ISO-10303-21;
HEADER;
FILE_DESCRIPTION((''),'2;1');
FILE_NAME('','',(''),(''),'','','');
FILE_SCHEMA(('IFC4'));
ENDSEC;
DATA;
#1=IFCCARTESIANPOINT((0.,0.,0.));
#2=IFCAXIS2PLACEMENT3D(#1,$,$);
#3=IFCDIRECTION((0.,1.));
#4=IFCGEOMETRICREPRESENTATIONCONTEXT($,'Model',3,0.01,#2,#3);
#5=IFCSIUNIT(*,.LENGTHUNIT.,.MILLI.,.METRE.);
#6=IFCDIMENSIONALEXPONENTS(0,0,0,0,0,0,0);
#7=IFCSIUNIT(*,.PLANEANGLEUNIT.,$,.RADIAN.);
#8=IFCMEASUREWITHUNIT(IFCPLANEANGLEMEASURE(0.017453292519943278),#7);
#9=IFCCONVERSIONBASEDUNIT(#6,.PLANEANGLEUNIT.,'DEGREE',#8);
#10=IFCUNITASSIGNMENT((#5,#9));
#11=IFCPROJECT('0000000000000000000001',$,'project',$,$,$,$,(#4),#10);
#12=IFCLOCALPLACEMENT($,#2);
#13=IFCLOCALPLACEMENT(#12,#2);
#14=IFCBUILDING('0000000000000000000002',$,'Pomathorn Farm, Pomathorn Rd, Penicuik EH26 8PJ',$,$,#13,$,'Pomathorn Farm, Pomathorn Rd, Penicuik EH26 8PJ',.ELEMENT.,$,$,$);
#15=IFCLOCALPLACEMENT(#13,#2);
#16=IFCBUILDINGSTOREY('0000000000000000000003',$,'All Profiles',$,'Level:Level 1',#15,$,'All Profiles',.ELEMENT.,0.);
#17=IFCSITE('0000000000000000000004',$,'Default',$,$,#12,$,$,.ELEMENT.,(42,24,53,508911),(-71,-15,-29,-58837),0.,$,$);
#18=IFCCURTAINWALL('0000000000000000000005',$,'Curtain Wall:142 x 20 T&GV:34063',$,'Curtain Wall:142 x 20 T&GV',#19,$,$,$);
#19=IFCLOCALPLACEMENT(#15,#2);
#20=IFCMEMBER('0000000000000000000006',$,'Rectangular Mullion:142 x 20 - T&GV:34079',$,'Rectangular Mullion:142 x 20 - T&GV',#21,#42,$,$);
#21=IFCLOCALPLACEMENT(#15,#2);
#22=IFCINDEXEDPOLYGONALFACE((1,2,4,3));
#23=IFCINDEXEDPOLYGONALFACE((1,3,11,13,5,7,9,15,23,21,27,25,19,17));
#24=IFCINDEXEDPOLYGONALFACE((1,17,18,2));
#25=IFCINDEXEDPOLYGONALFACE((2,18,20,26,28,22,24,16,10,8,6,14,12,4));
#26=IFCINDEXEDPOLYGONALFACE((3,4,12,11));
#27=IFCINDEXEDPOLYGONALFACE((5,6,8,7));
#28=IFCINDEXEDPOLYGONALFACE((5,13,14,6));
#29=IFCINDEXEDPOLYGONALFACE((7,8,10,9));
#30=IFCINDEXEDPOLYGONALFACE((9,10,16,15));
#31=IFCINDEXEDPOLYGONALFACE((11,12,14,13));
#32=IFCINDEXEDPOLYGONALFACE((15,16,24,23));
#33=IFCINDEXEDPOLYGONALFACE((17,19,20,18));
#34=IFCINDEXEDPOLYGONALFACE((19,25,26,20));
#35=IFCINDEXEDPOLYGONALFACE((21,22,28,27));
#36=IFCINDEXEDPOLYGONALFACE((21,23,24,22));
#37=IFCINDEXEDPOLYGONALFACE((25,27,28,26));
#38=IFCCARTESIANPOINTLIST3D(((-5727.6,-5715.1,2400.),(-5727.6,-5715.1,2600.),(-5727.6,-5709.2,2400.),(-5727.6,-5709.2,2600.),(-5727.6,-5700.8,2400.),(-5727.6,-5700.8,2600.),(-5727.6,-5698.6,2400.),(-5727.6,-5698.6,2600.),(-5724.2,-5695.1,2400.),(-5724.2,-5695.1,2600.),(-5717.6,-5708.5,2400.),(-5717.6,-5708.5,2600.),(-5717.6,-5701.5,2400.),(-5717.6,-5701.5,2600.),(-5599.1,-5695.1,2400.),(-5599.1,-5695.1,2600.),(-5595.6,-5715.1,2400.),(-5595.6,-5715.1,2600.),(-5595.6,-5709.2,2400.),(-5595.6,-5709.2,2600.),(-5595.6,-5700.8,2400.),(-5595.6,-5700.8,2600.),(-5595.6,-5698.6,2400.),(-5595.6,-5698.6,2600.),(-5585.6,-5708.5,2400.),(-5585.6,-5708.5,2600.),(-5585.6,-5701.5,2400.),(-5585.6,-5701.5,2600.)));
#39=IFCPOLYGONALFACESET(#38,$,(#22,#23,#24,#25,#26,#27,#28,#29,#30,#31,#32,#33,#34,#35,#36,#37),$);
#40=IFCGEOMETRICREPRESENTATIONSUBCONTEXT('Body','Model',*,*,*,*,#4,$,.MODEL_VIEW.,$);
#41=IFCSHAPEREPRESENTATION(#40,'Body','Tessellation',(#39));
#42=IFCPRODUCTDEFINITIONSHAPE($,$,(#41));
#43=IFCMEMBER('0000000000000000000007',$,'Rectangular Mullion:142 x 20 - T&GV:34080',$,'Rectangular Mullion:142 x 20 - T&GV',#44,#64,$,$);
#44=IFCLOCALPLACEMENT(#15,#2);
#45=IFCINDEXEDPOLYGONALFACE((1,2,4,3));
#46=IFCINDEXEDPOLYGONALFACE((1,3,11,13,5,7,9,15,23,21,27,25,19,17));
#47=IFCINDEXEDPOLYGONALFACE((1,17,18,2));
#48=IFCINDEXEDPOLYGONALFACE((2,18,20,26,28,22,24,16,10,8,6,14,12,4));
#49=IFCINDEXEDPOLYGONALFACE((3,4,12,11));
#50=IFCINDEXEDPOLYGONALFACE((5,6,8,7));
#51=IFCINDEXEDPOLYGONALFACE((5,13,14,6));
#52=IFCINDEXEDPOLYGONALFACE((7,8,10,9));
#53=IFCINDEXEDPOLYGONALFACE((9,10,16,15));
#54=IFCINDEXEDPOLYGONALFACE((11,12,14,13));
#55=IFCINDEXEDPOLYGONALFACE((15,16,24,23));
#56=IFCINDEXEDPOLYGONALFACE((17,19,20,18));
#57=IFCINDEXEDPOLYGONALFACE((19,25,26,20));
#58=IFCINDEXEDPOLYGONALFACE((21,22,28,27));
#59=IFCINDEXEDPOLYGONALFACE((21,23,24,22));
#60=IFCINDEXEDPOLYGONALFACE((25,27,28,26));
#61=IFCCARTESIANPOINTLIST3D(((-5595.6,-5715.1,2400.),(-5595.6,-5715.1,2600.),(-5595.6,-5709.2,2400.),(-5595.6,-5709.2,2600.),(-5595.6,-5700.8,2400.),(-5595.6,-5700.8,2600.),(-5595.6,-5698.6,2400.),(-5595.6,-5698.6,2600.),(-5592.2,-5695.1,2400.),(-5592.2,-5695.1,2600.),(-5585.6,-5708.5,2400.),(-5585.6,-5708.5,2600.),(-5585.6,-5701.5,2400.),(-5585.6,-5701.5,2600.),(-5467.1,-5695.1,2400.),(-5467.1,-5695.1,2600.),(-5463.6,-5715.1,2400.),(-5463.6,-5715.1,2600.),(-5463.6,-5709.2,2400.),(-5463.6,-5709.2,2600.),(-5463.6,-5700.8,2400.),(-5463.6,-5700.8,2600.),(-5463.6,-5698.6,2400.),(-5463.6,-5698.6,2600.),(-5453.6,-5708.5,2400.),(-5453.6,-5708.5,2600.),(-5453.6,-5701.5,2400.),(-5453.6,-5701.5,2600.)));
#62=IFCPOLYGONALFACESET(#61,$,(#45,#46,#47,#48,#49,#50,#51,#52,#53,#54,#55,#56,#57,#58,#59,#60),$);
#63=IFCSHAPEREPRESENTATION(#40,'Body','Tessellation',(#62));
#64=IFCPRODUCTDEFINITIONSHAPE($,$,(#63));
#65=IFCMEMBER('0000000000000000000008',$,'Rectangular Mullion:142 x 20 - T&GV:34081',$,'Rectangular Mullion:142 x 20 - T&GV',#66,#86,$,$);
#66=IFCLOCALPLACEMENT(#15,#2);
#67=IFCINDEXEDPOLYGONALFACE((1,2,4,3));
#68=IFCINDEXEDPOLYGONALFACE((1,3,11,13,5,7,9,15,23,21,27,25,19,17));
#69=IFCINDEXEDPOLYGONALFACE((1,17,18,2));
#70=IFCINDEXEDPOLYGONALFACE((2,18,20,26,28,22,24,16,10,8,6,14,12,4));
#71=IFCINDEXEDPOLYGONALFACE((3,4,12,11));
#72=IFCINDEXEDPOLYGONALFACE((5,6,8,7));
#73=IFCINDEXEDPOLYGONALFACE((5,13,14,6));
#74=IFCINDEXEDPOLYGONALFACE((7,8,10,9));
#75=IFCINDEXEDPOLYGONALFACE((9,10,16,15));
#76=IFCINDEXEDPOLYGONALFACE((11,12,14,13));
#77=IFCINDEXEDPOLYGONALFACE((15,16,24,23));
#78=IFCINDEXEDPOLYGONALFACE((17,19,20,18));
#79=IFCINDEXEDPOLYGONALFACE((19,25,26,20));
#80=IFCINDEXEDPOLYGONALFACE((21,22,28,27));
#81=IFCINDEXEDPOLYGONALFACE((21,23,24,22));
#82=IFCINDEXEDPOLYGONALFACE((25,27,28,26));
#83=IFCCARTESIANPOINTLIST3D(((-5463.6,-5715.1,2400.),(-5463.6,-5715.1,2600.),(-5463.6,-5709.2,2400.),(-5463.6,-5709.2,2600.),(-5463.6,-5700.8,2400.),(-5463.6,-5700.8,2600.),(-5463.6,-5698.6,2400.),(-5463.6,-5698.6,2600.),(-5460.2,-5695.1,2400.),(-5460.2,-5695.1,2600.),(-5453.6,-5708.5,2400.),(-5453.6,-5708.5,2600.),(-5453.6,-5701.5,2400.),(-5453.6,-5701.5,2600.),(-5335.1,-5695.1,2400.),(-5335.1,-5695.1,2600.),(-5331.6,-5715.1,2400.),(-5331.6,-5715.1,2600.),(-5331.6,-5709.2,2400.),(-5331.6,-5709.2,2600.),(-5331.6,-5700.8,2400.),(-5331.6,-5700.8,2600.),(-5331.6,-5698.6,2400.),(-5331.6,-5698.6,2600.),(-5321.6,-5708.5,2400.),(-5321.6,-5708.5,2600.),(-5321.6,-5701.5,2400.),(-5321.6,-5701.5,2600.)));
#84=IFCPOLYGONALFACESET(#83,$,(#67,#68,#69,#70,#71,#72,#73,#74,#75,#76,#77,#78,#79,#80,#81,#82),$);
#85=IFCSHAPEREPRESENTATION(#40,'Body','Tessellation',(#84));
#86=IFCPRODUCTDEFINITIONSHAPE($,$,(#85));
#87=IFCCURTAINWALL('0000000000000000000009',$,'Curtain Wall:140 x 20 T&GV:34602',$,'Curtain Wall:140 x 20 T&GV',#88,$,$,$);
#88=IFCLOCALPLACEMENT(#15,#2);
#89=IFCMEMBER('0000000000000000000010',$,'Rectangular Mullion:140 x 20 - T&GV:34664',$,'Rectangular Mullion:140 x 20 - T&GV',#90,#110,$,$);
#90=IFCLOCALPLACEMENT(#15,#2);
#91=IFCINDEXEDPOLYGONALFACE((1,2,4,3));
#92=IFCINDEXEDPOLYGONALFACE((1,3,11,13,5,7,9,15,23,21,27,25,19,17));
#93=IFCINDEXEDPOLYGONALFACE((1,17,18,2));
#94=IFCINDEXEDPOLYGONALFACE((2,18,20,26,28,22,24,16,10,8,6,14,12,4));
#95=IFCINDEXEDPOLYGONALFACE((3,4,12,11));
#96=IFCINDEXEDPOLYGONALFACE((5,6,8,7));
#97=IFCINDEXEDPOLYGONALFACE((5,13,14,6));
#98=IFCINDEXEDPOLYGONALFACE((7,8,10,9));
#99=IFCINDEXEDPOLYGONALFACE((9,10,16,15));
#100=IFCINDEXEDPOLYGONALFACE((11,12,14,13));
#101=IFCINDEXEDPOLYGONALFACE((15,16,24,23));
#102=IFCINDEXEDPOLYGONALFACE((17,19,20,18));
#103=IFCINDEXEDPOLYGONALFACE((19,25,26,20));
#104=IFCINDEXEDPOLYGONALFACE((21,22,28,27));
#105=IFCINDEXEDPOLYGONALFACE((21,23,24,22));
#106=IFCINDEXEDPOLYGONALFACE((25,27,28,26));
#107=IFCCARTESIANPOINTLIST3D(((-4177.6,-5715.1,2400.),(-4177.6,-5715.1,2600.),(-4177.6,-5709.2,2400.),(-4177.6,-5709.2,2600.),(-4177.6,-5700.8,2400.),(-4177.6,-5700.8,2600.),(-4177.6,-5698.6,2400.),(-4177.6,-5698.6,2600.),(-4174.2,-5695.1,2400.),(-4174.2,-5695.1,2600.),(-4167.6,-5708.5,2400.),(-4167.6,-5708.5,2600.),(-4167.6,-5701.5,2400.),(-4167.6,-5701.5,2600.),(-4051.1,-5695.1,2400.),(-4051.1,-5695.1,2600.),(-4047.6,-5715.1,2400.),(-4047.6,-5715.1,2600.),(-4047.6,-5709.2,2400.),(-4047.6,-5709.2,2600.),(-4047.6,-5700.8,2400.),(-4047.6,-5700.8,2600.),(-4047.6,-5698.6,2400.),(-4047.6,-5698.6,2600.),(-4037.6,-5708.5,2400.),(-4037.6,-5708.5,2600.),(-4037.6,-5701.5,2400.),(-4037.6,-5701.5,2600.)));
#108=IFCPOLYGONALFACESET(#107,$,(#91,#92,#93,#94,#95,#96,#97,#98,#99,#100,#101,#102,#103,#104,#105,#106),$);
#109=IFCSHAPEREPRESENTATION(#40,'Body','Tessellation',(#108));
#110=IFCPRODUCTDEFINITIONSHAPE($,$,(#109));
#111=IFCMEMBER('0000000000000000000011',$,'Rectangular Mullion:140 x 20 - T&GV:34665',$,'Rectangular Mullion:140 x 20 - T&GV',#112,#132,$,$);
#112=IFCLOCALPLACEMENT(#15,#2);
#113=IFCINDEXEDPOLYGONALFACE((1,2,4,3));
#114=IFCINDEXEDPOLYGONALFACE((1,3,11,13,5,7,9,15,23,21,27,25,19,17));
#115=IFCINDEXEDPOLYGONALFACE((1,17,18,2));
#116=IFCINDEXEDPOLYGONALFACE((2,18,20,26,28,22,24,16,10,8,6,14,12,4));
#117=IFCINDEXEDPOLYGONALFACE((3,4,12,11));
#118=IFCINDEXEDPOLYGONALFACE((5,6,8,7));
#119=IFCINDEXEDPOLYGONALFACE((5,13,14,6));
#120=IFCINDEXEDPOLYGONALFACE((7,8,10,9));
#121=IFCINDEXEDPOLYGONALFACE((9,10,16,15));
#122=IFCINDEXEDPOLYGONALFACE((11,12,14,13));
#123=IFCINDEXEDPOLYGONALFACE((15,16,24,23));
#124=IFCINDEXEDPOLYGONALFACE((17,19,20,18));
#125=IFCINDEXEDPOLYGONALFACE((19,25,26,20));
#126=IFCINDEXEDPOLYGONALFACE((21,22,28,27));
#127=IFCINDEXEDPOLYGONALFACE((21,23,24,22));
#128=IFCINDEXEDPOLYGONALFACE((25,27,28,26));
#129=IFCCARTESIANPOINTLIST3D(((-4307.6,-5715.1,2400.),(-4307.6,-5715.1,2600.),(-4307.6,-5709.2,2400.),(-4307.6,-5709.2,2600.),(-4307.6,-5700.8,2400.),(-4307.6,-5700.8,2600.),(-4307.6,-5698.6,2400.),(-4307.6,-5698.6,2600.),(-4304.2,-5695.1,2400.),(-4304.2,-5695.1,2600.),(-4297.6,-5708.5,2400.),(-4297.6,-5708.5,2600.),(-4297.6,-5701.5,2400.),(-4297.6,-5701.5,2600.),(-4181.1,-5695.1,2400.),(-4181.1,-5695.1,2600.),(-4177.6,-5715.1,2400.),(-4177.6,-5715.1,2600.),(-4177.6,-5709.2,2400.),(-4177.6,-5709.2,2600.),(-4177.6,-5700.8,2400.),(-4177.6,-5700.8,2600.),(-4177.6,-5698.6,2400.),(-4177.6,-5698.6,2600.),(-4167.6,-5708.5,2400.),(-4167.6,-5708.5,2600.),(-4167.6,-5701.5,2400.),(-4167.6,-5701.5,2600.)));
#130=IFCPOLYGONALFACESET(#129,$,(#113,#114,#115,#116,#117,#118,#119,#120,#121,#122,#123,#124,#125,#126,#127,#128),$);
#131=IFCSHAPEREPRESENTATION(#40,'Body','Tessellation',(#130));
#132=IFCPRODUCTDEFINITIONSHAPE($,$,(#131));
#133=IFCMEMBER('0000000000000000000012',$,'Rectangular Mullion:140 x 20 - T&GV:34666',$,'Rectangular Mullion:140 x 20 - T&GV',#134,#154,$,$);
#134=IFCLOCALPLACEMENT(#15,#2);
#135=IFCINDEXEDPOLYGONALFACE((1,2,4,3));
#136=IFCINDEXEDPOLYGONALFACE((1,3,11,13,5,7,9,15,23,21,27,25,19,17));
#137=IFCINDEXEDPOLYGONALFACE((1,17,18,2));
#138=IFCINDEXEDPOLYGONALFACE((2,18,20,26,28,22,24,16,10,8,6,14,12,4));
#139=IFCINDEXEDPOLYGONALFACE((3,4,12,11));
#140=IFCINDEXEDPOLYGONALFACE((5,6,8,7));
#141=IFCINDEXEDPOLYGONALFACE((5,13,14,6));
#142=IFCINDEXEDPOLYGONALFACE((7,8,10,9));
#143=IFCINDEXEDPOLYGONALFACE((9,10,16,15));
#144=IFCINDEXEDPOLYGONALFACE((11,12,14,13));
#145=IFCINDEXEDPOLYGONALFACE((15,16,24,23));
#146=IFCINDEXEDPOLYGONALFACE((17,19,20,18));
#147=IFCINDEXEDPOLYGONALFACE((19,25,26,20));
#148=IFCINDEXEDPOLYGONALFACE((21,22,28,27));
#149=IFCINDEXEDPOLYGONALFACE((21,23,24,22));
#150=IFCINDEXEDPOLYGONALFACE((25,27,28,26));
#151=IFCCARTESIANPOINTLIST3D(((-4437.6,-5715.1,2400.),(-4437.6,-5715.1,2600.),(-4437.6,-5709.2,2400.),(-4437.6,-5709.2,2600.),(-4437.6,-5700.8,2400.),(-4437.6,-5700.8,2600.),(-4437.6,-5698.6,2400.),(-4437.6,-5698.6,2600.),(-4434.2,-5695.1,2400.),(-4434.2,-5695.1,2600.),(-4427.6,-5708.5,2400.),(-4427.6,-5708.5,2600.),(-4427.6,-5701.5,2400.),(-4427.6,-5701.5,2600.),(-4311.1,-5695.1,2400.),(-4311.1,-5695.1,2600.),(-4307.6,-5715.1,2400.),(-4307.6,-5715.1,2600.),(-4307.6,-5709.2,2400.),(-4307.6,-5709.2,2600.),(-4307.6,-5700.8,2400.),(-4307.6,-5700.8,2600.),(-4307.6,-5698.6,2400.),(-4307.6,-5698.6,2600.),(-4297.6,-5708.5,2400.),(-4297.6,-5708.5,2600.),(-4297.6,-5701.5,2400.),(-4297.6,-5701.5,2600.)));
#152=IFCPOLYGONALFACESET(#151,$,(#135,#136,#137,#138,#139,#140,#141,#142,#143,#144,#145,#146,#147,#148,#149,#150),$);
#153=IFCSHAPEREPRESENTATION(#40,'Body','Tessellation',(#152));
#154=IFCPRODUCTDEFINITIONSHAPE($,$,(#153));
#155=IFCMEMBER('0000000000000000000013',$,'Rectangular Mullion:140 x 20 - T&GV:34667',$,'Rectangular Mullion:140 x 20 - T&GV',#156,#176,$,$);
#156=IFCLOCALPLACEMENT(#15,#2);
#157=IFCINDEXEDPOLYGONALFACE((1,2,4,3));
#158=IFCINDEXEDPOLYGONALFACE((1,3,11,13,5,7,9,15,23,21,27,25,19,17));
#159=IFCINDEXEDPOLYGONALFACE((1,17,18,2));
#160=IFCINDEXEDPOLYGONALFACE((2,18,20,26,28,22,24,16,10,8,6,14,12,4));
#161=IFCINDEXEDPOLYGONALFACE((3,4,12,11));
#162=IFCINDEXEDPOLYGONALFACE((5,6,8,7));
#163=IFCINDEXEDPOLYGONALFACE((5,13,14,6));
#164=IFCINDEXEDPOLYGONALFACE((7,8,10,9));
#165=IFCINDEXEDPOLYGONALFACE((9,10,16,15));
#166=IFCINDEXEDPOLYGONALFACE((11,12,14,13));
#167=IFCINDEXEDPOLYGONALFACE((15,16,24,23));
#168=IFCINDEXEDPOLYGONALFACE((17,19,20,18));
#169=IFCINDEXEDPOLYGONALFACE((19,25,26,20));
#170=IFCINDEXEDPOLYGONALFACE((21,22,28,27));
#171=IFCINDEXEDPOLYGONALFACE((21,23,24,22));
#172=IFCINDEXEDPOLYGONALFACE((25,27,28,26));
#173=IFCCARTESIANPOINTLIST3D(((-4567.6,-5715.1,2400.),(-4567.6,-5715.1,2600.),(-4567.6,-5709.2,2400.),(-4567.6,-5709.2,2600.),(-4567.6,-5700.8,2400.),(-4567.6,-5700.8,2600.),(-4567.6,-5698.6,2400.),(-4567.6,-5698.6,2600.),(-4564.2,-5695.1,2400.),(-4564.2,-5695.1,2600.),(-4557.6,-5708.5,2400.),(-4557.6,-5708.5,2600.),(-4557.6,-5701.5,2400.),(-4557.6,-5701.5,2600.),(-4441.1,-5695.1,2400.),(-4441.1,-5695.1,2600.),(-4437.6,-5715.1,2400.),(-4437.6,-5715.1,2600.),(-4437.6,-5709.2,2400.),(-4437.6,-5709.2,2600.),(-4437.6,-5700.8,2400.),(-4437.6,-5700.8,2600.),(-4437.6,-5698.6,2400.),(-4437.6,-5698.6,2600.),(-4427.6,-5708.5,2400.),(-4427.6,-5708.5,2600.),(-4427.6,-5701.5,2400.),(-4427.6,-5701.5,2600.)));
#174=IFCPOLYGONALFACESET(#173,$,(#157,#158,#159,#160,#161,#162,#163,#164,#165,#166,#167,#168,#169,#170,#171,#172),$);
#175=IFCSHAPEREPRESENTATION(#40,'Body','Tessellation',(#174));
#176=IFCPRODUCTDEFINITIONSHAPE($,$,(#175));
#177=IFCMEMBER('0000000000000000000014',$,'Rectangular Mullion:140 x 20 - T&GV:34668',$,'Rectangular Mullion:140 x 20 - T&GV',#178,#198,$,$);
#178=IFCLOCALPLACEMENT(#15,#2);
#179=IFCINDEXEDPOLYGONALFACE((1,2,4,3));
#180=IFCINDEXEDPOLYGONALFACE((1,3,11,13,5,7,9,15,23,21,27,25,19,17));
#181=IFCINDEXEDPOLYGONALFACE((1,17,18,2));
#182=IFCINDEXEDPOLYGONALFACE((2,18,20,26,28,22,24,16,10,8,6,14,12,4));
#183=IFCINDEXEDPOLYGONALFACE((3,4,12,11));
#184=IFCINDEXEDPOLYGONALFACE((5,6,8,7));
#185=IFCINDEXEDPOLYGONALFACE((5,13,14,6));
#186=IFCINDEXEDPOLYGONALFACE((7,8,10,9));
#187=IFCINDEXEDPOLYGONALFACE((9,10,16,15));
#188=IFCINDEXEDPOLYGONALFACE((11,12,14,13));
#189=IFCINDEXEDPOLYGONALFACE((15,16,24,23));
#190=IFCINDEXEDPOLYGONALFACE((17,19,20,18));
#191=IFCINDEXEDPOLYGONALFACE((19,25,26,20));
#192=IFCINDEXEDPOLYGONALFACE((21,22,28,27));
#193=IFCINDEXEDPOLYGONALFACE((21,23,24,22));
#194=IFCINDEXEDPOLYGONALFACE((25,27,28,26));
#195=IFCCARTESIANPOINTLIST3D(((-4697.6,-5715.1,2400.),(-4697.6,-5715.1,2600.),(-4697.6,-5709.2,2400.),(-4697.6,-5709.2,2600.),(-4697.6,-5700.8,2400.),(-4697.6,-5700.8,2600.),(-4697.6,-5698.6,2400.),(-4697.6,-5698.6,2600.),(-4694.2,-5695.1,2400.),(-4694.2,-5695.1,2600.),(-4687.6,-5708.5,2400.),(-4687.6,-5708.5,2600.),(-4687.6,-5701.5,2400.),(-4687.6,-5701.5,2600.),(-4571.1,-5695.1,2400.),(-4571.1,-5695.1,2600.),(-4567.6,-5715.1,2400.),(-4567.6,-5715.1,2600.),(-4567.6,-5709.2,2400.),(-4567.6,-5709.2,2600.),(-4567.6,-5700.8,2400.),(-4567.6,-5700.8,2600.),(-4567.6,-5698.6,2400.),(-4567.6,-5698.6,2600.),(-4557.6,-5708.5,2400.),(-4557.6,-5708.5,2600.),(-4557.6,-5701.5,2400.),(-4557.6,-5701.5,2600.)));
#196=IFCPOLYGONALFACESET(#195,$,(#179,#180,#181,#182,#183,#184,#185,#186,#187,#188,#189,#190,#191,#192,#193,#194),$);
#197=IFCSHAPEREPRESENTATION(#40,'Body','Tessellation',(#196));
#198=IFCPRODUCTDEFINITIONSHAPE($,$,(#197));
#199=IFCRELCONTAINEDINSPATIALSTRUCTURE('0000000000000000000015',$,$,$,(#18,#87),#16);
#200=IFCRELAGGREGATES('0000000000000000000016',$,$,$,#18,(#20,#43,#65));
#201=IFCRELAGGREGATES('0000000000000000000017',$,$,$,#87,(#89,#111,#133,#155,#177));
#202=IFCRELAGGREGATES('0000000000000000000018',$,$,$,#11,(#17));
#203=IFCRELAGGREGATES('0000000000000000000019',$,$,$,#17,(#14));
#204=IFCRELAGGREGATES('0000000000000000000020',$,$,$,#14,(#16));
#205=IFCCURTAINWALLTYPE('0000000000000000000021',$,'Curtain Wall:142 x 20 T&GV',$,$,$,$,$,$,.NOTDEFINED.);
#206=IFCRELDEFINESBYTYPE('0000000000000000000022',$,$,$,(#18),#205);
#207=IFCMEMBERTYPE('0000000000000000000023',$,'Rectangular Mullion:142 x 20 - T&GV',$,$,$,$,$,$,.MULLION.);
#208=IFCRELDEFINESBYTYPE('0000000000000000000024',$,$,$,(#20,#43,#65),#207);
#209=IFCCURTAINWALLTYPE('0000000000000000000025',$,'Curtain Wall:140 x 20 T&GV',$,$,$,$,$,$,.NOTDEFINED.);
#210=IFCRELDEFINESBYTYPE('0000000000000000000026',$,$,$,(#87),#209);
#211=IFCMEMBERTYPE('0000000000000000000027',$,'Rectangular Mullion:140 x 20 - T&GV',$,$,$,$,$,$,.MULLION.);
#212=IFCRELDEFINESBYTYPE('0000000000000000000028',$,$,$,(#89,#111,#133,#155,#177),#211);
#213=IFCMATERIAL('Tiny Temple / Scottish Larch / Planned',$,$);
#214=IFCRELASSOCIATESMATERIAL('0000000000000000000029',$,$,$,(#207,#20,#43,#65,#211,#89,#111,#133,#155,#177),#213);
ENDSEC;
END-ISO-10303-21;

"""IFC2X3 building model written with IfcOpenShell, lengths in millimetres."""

from ifc_helpers import new_model, entity, si_unit, converted_unit, direction, frame, origin, place, context, subcontext, project, spatial, polyline, outline, extrude, source, transform, mapped, material, type_object, type_shapes, element, aggregate, save


model = new_model("IFC2X3")

# Units and contexts
model_context = context("Model", 3, precision=0.01, world=origin(), true_north=direction((0.0, 1.0)))
body_context = subcontext(model_context, "Body", "Model", "MODEL_VIEW")
ifc_project = project(units=[si_unit("LENGTHUNIT", "METRE", prefix="MILLI"), converted_unit("PLANEANGLEUNIT", "DEGREE", entity("IfcPlaneAngleMeasure", 0.017453292519943278), si_unit("PLANEANGLEUNIT", "RADIAN"), dimensions=[0, 0, 0, 0, 0, 0, 0])], contexts=[model_context])

# Site, building, storey
site_placement = place(None, origin())
site = spatial("IfcSite", under=ifc_project, at=site_placement, Name="Default", CompositionType="ELEMENT", RefLatitude=(42, 24, 53, 508911), RefLongitude=(-71, -15, -29, -58837), RefElevation=0.0)
building_placement = place(site_placement, origin())
building = spatial("IfcBuilding", under=site, at=building_placement, Name="Pomathorn Farm, Pomathorn Rd, Penicuik EH26 8PJ", LongName="Pomathorn Farm, Pomathorn Rd, Penicuik EH26 8PJ", CompositionType="ELEMENT")
storey_placement = place(building_placement, origin())
storey = spatial("IfcBuildingStorey", under=building, at=storey_placement, Name="All Profiles", ObjectType="Level:Level 1", LongName="All Profiles", CompositionType="ELEMENT", Elevation=0.0)

# Curtain walls, members
ifc_material = material(Name="Tiny Temple / Scottish Larch / Planned")
curtain_wall_type_1 = type_object("IfcCurtainWallType", Name="Curtain Wall:142 x 20 T&GV", PredefinedType="NOTDEFINED")
curtain_wall_1_placement = place(storey_placement, origin())
curtain_wall_1 = element("IfcCurtainWall", 1, at=curtain_wall_1_placement, inside=storey, type_object=curtain_wall_type_1, Name="Curtain Wall:142 x 20 T&GV:34063", ObjectType="Curtain Wall:142 x 20 T&GV")
member_type_1 = type_object("IfcMemberType", Name="Rectangular Mullion:142 x 20 - T&GV", PredefinedType="MULLION", material=ifc_material)
shared_shape_1 = source(origin(), body_context, "Body", "SweptSolid", [
    extrude(outline(polyline([(-63.1, -11.0), (68.9, -11.0), (68.9, -5.1), (58.9, -4.4), (58.9, 2.6), (68.9, 3.3), (68.9, 5.5), (65.4, 9.0), (-59.7, 9.0), (-63.1, 5.5), (-63.1, 3.3), (-73.1, 2.6), (-73.1, -4.4), (-63.1, -5.1), (-63.1, -11.0)])), frame((-73.1, -11.0, -200.0), z_axis=(0.0, 0.0, 1.0), x_axis=(-1.0, 0.0, 0.0)), (0.0, 0.0, 1.0), 200.0),
])
type_shapes(member_type_1, [shared_shape_1])
member_1_placement = place(curtain_wall_1_placement, frame((-5585.6, -5715.1, 2400.0), z_axis=(0.0, 0.0, -1.0), x_axis=(1.0, 0.0, 0.0)))
member_1 = element("IfcMember", 2, at=member_1_placement, type_object=member_type_1, material=ifc_material, Name="Rectangular Mullion:142 x 20 - T&GV:34079", ObjectType="Rectangular Mullion:142 x 20 - T&GV", context=body_context, shape_type="MappedRepresentation", body=[
    mapped(shared_shape_1, transform((0.0, 0.0, 0.0), scale=1.0)),
])
member_2_placement = place(curtain_wall_1_placement, frame((-5453.6, -5715.1, 2400.0), z_axis=(0.0, 0.0, -1.0), x_axis=(1.0, 0.0, 0.0)))
member_2 = element("IfcMember", 3, at=member_2_placement, type_object=member_type_1, material=ifc_material, Name="Rectangular Mullion:142 x 20 - T&GV:34080", ObjectType="Rectangular Mullion:142 x 20 - T&GV", context=body_context, shape_type="MappedRepresentation", body=[
    mapped(shared_shape_1, transform((0.0, 0.0, 0.0), scale=1.0)),
])
member_3_placement = place(curtain_wall_1_placement, frame((-5321.6, -5715.1, 2400.0), z_axis=(0.0, 0.0, -1.0), x_axis=(1.0, 0.0, 0.0)))
member_3 = element("IfcMember", 4, at=member_3_placement, type_object=member_type_1, material=ifc_material, Name="Rectangular Mullion:142 x 20 - T&GV:34081", ObjectType="Rectangular Mullion:142 x 20 - T&GV", context=body_context, shape_type="MappedRepresentation", body=[
    mapped(shared_shape_1, transform((0.0, 0.0, 0.0), scale=1.0)),
])
aggregate(curtain_wall_1, [member_1, member_2, member_3])
curtain_wall_type_2 = type_object("IfcCurtainWallType", Name="Curtain Wall:140 x 20 T&GV", PredefinedType="NOTDEFINED")
curtain_wall_2_placement = place(storey_placement, origin())
curtain_wall_2 = element("IfcCurtainWall", 5, at=curtain_wall_2_placement, inside=storey, type_object=curtain_wall_type_2, Name="Curtain Wall:140 x 20 T&GV:34602", ObjectType="Curtain Wall:140 x 20 T&GV")
member_type_2 = type_object("IfcMemberType", Name="Rectangular Mullion:140 x 20 - T&GV", PredefinedType="MULLION", material=ifc_material)
shared_shape_2 = source(origin(), body_context, "Body", "SweptSolid", [
    extrude(outline(polyline([(-62.1, -11.0), (67.9, -11.0), (67.9, -5.1), (57.9, -4.4), (57.9, 2.6), (67.9, 3.3), (67.9, 5.5), (64.4, 9.0), (-58.7, 9.0), (-62.1, 5.5), (-62.1, 3.3), (-72.1, 2.6), (-72.1, -4.4), (-62.1, -5.1), (-62.1, -11.0)])), frame((-72.1, -11.0, -200.0), z_axis=(0.0, 0.0, 1.0), x_axis=(-1.0, 0.0, 0.0)), (0.0, 0.0, 1.0), 200.0),
])
type_shapes(member_type_2, [shared_shape_2])
member_4_placement = place(curtain_wall_2_placement, frame((-4037.6, -5715.1, 2400.0), z_axis=(0.0, 0.0, -1.0), x_axis=(1.0, 0.0, 0.0)))
member_4 = element("IfcMember", 6, at=member_4_placement, type_object=member_type_2, material=ifc_material, Name="Rectangular Mullion:140 x 20 - T&GV:34664", ObjectType="Rectangular Mullion:140 x 20 - T&GV", context=body_context, shape_type="MappedRepresentation", body=[
    mapped(shared_shape_2, transform((0.0, 0.0, 0.0), scale=1.0)),
])
member_5_placement = place(curtain_wall_2_placement, frame((-4167.6, -5715.1, 2400.0), z_axis=(0.0, 0.0, -1.0), x_axis=(1.0, 0.0, 0.0)))
member_5 = element("IfcMember", 7, at=member_5_placement, type_object=member_type_2, material=ifc_material, Name="Rectangular Mullion:140 x 20 - T&GV:34665", ObjectType="Rectangular Mullion:140 x 20 - T&GV", context=body_context, shape_type="MappedRepresentation", body=[
    mapped(shared_shape_2, transform((0.0, 0.0, 0.0), scale=1.0)),
])
member_6_placement = place(curtain_wall_2_placement, frame((-4297.6, -5715.1, 2400.0), z_axis=(0.0, 0.0, -1.0), x_axis=(1.0, 0.0, 0.0)))
member_6 = element("IfcMember", 8, at=member_6_placement, type_object=member_type_2, material=ifc_material, Name="Rectangular Mullion:140 x 20 - T&GV:34666", ObjectType="Rectangular Mullion:140 x 20 - T&GV", context=body_context, shape_type="MappedRepresentation", body=[
    mapped(shared_shape_2, transform((0.0, 0.0, 0.0), scale=1.0)),
])
member_7_placement = place(curtain_wall_2_placement, frame((-4427.6, -5715.1, 2400.0), z_axis=(0.0, 0.0, -1.0), x_axis=(1.0, 0.0, 0.0)))
member_7 = element("IfcMember", 9, at=member_7_placement, type_object=member_type_2, material=ifc_material, Name="Rectangular Mullion:140 x 20 - T&GV:34667", ObjectType="Rectangular Mullion:140 x 20 - T&GV", context=body_context, shape_type="MappedRepresentation", body=[
    mapped(shared_shape_2, transform((0.0, 0.0, 0.0), scale=1.0)),
])
member_8_placement = place(curtain_wall_2_placement, frame((-4557.6, -5715.1, 2400.0), z_axis=(0.0, 0.0, -1.0), x_axis=(1.0, 0.0, 0.0)))
member_8 = element("IfcMember", 10, at=member_8_placement, type_object=member_type_2, material=ifc_material, Name="Rectangular Mullion:140 x 20 - T&GV:34668", ObjectType="Rectangular Mullion:140 x 20 - T&GV", context=body_context, shape_type="MappedRepresentation", body=[
    mapped(shared_shape_2, transform((0.0, 0.0, 0.0), scale=1.0)),
])
aggregate(curtain_wall_2, [member_4, member_5, member_6, member_7, member_8])

save(model, "model.ifc")
